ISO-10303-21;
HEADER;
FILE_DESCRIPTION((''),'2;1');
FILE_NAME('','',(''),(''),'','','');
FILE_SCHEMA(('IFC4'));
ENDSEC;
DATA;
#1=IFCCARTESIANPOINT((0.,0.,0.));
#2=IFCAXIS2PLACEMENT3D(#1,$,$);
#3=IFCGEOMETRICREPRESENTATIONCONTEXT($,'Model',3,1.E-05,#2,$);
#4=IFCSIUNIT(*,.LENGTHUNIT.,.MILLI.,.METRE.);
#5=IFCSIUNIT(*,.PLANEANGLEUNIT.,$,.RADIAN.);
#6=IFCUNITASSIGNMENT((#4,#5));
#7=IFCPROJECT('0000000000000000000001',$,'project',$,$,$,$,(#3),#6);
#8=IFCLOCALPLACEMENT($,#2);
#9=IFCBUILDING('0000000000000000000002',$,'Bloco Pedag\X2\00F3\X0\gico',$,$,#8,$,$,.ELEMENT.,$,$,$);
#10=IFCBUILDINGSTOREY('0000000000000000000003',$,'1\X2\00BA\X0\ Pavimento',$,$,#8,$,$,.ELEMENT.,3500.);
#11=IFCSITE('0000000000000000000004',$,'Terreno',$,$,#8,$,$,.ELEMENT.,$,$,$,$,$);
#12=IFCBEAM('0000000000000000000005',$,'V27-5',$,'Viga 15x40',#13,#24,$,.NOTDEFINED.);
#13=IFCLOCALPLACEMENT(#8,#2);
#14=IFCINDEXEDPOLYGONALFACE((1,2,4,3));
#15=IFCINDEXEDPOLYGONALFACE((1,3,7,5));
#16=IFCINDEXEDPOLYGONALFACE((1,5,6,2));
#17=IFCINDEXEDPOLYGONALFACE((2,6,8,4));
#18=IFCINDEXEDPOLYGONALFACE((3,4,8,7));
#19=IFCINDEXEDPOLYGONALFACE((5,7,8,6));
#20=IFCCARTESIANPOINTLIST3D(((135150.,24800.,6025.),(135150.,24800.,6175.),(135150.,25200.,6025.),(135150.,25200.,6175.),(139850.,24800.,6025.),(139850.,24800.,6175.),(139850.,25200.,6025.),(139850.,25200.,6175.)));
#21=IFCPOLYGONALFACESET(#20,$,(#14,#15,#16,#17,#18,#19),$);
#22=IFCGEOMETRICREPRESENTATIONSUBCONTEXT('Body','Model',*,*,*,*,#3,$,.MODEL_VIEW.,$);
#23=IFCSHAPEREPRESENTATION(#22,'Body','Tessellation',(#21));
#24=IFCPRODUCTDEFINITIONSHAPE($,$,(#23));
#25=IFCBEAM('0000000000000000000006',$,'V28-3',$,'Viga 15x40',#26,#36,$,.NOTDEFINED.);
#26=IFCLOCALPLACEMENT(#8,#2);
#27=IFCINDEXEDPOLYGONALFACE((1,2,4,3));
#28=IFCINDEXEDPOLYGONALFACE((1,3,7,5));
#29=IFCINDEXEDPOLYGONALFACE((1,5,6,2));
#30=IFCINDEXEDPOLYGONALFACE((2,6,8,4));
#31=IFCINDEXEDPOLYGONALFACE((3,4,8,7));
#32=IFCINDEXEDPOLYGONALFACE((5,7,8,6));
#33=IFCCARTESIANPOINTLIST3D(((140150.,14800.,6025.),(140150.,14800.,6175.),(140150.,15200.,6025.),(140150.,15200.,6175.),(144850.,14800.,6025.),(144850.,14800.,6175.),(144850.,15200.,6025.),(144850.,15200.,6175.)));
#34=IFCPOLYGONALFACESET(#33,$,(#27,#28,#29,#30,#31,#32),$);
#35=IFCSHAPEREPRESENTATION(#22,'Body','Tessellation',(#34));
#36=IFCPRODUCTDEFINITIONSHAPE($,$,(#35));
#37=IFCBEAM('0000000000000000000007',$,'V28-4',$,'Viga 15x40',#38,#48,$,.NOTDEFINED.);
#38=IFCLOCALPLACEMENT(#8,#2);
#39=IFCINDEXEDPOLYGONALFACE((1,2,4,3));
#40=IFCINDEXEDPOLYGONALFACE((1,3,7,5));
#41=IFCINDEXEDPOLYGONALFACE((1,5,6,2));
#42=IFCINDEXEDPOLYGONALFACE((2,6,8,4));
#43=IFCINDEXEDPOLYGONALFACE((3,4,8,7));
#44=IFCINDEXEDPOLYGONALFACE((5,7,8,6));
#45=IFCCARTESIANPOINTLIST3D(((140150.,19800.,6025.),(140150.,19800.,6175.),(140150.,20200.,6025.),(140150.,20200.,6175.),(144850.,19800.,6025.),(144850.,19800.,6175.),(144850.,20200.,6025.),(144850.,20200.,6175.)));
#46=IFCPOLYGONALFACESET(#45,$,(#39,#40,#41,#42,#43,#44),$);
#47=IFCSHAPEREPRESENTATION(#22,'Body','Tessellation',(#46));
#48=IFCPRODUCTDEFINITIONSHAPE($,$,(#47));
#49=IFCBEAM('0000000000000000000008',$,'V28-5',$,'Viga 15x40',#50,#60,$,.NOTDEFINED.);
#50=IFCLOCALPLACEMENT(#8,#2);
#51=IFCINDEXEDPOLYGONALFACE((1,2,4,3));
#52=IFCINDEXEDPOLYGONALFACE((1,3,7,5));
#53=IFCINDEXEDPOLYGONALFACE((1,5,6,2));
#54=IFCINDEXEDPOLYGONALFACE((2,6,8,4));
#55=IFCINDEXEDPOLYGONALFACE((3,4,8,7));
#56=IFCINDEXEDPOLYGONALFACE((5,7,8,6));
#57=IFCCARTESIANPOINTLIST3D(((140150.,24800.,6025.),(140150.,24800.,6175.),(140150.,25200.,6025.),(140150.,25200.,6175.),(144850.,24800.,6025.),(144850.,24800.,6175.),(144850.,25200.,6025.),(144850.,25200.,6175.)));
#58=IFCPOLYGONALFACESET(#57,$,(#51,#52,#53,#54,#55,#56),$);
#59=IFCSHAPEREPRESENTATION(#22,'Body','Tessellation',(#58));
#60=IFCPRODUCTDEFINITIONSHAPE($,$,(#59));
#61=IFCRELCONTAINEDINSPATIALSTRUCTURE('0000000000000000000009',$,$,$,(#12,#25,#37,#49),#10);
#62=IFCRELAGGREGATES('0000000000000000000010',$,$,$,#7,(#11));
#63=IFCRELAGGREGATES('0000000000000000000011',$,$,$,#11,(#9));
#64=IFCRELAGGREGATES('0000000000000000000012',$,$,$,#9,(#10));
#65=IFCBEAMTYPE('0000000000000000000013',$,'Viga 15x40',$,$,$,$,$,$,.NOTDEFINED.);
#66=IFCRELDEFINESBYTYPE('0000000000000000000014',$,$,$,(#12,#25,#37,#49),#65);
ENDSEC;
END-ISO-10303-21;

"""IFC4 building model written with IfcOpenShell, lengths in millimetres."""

from ifc_helpers import new_model, si_unit, frame, origin, origin_2d, place, context, subcontext, project, spatial, rectangle, extrude, type_object, element, save


model = new_model("IFC4")

# Units and contexts
model_context = context("Model", 3, precision=1e-05, world=origin())
body_context = subcontext(model_context, "Body", "Model", "MODEL_VIEW")
ifc_project = project(units=[si_unit("LENGTHUNIT", "METRE", prefix="MILLI"), si_unit("PLANEANGLEUNIT", "RADIAN")], contexts=[model_context])

# Site, building, storey
placement = place(None, origin())
site = spatial("IfcSite", under=ifc_project, at=placement, Name="Terreno", CompositionType="ELEMENT")
building = spatial("IfcBuilding", under=site, at=placement, Name="Bloco Pedagógico", CompositionType="ELEMENT")
storey = spatial("IfcBuildingStorey", under=building, at=placement, Name="1º Pavimento", CompositionType="ELEMENT", Elevation=3500.0)

# Beams
beam_type = type_object("IfcBeamType", Name="Viga 15x40", PredefinedType="NOTDEFINED")
for number, where, z_axis, x_axis, name in (
    (1, (135150.0, 25000.0, 6100.0), (1.0, 0.0, 0.0), (0.0, 1.0, 0.0), "V27-5"),
    (2, (140150.0, 15000.0, 6100.0), (1.0, 0.0, 0.0), (0.0, 1.0, 0.0), "V28-3"),
    (3, (140150.0, 20000.0, 6100.0), (1.0, 0.0, 0.0), (0.0, 1.0, 0.0), "V28-4"),
    (4, (140150.0, 25000.0, 6100.0), (1.0, 0.0, 0.0), (0.0, 1.0, 0.0), "V28-5"),
):
    element("IfcBeam", number, at=place(None, frame(where, z_axis=z_axis, x_axis=x_axis)), inside=storey, type_object=beam_type, Name=name, ObjectType="Viga 15x40", PredefinedType="NOTDEFINED", context=body_context, shape_type="SweptSolid", body=[
        extrude(rectangle(XDim=400.0, YDim=150.0, at=origin_2d()), None, (0.0, 0.0, 1.0), 4700.0),
    ])

save(model, "model.ifc")
